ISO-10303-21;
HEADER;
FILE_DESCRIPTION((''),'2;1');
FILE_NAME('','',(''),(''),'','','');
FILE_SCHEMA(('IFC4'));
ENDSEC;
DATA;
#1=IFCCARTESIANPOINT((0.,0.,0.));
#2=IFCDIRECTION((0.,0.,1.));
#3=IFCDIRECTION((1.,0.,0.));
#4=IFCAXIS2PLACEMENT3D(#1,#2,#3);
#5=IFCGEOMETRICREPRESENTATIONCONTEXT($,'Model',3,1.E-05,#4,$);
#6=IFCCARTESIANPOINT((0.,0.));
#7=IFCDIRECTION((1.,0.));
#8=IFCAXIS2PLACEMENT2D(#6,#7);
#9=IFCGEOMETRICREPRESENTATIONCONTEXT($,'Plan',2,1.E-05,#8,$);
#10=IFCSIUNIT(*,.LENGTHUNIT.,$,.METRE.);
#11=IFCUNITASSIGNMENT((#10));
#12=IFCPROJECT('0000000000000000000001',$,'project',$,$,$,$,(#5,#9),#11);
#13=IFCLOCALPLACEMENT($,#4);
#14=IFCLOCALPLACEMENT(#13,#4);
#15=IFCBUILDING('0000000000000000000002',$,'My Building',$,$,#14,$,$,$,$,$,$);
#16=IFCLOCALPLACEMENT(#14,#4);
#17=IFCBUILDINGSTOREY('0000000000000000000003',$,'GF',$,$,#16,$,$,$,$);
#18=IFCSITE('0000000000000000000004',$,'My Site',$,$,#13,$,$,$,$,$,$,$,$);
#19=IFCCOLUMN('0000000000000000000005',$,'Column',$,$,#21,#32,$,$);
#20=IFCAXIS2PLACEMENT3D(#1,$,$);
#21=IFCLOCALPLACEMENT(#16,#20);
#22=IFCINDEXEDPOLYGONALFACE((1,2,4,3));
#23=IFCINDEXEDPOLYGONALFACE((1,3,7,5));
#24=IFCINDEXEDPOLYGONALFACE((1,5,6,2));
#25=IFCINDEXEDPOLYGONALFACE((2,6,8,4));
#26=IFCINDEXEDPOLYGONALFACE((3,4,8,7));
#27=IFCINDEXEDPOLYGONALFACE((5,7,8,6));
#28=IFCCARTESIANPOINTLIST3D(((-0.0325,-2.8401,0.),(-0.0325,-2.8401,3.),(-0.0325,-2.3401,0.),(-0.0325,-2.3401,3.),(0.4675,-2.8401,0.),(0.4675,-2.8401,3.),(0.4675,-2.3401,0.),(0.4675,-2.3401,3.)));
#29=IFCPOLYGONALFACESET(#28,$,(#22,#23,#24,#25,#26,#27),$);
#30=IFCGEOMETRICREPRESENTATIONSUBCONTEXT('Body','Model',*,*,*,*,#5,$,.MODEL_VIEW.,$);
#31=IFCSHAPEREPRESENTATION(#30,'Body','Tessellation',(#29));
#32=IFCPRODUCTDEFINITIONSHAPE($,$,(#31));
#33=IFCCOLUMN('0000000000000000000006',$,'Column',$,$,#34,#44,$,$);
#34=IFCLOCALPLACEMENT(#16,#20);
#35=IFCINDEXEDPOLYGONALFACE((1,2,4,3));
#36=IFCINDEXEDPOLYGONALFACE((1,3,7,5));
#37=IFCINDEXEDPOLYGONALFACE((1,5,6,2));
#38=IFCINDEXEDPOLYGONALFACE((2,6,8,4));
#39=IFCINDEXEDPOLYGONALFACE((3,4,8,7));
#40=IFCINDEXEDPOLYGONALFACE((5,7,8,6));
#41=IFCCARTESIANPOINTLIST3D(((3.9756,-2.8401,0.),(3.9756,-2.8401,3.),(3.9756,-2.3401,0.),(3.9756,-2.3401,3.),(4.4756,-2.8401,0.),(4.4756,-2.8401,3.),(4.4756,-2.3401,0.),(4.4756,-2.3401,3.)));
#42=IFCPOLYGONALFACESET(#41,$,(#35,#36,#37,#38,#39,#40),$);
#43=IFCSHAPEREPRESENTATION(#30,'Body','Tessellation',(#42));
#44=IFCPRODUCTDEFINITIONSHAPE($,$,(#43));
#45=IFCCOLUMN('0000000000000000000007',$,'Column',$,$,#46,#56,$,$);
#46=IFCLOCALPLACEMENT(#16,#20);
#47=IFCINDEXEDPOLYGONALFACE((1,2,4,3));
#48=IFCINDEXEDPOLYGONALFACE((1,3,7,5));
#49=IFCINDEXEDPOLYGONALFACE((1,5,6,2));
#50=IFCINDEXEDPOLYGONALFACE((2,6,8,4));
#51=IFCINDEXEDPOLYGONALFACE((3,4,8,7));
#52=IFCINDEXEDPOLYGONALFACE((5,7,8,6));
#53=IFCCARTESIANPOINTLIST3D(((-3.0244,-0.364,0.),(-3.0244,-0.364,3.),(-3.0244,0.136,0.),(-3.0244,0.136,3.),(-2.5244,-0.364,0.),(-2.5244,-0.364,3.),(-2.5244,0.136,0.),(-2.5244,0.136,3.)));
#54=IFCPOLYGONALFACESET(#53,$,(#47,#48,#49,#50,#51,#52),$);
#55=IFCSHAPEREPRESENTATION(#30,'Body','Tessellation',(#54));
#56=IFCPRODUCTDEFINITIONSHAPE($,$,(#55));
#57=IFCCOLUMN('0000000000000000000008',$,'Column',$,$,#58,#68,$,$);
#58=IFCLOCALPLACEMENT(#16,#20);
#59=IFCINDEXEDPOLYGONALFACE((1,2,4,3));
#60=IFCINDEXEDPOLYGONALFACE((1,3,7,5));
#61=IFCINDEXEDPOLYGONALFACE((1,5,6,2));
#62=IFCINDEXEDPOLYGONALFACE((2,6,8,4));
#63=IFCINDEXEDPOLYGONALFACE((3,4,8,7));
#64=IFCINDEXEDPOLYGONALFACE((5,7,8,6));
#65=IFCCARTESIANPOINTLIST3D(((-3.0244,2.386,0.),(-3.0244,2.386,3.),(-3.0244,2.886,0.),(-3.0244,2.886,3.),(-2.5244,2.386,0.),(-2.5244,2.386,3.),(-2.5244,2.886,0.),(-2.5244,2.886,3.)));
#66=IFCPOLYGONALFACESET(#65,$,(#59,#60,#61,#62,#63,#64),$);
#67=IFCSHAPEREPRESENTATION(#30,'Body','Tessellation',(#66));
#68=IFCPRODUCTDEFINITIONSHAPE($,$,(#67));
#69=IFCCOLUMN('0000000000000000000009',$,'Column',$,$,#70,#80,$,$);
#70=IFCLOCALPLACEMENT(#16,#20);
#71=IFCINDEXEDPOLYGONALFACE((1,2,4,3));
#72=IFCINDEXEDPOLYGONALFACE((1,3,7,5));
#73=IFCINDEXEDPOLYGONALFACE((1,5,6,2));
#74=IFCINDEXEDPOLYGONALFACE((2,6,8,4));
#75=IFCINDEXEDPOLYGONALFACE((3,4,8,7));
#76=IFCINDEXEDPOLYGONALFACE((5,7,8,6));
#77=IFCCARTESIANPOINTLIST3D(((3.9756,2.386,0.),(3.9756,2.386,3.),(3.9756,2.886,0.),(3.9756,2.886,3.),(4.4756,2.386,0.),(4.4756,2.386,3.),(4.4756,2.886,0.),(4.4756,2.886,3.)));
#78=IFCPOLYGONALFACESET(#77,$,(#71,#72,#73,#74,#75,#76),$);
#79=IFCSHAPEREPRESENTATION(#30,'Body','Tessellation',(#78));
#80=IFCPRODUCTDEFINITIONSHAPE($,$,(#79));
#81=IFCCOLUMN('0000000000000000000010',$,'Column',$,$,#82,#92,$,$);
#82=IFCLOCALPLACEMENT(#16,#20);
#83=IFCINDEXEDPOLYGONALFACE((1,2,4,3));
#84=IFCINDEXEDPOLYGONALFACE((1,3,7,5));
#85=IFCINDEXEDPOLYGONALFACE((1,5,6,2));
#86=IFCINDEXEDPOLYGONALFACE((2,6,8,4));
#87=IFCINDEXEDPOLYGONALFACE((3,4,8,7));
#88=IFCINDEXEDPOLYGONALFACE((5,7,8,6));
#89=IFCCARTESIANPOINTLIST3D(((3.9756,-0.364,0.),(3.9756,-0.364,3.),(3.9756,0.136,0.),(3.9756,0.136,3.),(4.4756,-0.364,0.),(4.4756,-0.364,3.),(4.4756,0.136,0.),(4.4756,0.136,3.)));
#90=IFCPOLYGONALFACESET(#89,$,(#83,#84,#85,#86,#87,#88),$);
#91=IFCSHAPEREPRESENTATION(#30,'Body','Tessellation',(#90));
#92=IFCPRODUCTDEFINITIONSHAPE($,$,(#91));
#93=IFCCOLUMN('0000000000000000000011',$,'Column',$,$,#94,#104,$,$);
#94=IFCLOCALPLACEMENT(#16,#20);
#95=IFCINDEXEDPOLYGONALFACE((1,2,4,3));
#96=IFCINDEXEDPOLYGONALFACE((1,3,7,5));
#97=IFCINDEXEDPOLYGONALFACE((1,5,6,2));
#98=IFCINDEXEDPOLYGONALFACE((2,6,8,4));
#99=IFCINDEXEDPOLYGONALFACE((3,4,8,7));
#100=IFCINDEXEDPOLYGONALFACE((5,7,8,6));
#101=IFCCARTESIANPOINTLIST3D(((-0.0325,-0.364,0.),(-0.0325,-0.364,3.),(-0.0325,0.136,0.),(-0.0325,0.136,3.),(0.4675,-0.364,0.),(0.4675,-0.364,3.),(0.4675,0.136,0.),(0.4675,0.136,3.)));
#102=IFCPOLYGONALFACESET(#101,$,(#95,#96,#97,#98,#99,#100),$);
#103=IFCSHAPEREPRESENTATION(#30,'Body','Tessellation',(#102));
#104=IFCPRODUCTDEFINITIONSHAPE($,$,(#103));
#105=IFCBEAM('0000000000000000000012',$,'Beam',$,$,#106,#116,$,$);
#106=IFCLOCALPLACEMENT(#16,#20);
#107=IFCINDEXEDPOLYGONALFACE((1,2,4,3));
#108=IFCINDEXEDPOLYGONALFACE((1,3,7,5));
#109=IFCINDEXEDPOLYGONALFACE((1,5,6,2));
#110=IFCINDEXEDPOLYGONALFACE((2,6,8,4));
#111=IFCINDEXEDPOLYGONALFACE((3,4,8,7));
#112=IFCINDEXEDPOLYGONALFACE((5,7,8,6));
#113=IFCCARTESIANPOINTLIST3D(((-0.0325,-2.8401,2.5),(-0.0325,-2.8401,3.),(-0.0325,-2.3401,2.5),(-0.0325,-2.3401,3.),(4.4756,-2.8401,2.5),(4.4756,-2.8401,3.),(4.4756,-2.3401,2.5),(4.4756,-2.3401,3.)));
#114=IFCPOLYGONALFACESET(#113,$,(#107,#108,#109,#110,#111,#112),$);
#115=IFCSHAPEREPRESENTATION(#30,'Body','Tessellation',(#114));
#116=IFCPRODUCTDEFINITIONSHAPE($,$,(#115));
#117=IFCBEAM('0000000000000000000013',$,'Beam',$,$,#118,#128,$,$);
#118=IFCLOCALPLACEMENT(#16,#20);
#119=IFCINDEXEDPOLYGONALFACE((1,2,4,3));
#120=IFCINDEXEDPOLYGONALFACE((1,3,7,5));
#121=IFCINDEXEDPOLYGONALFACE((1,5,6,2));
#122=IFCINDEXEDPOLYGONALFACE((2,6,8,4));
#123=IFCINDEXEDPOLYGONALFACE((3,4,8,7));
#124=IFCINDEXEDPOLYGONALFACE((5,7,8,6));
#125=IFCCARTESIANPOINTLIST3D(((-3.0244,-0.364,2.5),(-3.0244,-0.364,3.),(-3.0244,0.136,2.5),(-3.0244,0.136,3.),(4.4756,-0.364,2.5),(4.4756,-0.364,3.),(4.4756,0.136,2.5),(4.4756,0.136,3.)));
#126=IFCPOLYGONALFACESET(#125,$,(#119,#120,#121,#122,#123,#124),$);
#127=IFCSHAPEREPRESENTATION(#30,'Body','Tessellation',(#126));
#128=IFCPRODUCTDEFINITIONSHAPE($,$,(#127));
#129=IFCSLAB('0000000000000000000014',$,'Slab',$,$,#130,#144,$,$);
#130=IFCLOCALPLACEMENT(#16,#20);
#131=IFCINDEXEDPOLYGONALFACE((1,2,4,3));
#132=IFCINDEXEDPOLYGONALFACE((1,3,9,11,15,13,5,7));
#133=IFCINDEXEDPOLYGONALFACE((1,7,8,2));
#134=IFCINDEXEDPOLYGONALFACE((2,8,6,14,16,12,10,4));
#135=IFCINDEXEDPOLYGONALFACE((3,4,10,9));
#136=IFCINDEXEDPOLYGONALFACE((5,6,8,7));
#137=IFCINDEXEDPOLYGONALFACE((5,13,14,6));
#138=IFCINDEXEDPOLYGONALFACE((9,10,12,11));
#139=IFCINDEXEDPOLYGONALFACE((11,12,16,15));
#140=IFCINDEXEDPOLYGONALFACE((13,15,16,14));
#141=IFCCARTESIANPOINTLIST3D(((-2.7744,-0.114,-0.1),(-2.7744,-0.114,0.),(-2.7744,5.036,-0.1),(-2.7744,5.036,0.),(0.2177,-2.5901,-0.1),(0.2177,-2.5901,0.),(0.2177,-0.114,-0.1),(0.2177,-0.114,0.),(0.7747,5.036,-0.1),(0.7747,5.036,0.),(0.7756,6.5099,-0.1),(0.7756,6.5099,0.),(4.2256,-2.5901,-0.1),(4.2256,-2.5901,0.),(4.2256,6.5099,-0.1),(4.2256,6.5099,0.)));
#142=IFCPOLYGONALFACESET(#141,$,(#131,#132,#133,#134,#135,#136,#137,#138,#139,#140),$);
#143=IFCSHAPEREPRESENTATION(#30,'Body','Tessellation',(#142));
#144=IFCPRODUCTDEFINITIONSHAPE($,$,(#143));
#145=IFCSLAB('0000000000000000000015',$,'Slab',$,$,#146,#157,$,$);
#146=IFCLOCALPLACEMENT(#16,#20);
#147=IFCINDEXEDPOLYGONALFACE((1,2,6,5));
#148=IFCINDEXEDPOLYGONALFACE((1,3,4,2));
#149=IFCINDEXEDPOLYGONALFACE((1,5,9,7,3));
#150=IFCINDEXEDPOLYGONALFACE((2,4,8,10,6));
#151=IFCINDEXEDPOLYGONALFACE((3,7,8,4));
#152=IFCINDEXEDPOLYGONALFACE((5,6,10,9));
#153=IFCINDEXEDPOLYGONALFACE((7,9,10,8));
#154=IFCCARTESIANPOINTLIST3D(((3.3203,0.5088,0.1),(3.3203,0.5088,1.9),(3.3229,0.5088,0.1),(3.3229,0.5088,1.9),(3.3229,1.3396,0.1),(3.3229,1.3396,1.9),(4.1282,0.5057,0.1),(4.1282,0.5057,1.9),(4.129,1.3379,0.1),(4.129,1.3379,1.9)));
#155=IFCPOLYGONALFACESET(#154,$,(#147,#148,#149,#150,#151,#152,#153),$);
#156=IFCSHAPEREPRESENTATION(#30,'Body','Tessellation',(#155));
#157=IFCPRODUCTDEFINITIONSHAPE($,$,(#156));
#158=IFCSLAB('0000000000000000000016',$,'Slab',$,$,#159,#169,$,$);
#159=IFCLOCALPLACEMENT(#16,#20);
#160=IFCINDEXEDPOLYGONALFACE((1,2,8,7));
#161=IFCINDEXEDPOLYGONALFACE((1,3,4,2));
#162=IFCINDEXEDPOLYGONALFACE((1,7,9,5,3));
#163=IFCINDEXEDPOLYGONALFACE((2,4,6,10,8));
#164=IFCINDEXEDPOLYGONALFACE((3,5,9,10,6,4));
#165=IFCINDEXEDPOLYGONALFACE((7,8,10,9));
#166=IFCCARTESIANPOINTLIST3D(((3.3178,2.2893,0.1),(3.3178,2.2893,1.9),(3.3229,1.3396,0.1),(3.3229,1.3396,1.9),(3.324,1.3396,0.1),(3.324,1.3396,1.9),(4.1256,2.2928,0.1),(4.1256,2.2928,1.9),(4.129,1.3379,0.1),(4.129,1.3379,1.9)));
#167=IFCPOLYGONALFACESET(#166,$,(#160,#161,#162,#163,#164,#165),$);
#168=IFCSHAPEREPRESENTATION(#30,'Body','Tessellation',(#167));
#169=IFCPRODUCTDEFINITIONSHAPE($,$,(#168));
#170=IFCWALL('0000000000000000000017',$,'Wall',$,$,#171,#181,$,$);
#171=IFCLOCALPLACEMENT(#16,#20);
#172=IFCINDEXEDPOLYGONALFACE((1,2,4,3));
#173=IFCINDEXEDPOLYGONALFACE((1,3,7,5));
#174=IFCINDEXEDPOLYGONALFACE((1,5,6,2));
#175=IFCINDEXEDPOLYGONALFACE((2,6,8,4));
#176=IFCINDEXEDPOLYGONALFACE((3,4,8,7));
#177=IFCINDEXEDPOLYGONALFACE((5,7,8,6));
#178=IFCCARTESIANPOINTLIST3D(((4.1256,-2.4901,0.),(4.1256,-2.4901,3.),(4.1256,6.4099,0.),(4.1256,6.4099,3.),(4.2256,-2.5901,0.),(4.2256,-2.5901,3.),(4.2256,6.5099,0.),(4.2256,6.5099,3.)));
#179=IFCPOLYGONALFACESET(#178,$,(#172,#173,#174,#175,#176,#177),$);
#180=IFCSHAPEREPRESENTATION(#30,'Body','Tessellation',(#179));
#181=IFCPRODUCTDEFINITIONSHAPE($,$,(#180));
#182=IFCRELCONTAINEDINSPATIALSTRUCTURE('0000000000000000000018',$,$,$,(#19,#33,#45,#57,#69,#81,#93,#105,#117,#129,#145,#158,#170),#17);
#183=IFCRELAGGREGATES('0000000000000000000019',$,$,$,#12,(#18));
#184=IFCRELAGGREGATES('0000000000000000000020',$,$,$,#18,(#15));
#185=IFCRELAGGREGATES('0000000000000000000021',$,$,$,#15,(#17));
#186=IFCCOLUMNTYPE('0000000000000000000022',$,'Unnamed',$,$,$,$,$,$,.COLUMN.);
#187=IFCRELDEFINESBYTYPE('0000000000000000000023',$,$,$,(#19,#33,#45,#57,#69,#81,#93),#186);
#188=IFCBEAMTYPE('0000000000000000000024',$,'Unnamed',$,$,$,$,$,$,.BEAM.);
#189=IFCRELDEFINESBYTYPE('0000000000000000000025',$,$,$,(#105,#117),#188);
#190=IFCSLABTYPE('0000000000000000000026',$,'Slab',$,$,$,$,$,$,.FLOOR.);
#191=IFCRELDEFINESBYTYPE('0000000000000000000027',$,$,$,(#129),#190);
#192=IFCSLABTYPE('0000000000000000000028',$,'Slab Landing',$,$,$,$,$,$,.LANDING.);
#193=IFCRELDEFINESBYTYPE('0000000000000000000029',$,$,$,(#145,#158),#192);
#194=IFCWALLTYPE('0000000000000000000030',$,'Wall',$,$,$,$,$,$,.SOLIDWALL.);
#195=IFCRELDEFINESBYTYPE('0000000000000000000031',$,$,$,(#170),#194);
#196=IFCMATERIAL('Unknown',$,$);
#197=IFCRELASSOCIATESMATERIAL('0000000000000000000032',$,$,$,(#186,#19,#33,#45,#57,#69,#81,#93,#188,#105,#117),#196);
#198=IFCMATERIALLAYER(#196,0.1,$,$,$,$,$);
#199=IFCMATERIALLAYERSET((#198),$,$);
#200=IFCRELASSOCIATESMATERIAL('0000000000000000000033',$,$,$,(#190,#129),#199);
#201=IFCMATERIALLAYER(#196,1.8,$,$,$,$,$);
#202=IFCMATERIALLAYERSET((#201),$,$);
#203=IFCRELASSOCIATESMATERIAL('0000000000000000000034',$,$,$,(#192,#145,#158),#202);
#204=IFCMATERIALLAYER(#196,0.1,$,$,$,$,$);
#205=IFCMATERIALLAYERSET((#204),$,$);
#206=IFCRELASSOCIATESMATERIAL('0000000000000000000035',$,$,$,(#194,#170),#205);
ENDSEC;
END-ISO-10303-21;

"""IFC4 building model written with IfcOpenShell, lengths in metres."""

from ifc_helpers import new_model, si_unit, frame, origin_with_axes, origin_2d_with_axis, place, context, subcontext, project, spatial, line, indexed_curve, rectangle, outline, extrude, material, layer, layer_set, layer_usage, material_profile, profile_set, profile_usage, type_object, element, save


model = new_model("IFC4")

# Units and contexts
model_context = context("Model", 3, precision=1e-05, world=origin_with_axes())
plan_context = context("Plan", 2, precision=1e-05, world=origin_2d_with_axis())
body_context_1 = subcontext(model_context, "Body", "Model", "MODEL_VIEW")
ifc_project = project(units=[si_unit("LENGTHUNIT", "METRE")], contexts=[model_context, plan_context])

# Site, building, storey
site_placement = place(None, origin_with_axes())
site = spatial("IfcSite", under=ifc_project, at=site_placement, Name="My Site")
building_placement = place(site_placement, origin_with_axes())
building = spatial("IfcBuilding", under=site, at=building_placement, Name="My Building")
storey_placement = place(building_placement, origin_with_axes())
storey = spatial("IfcBuildingStorey", under=building, at=storey_placement, Name="GF")

# Columns
ifc_material = material(Name="Unknown")
ifc_material_profile_1 = material_profile(ifc_material, rectangle(XDim=0.5, YDim=0.5))
ifc_profile_set_1 = profile_set([ifc_material_profile_1])
ifc_profile_usage_1 = profile_usage(ifc_profile_set_1, cardinal=5)
column_type = type_object("IfcColumnType", Name="Unnamed", PredefinedType="COLUMN", material=ifc_profile_set_1)
column_1_placement = place(storey_placement, frame((0.2175, -2.5901, 0.0), z_axis=(0.0, 0.0, 1.0), x_axis=(1.0, 0.0, 0.0)))
element("IfcColumn", 1, at=column_1_placement, inside=storey, type_object=column_type, material=ifc_profile_usage_1, Name="Column", context=body_context_1, shape_type="SweptSolid", body=[
    extrude(rectangle(XDim=0.5, YDim=0.5), origin_with_axes(), (0.0, 0.0, 1.0), 3.0),
])
ifc_profile_usage_2 = profile_usage(ifc_profile_set_1, cardinal=5)
column_2_placement = place(storey_placement, frame((4.2256, -2.5901, 0.0), z_axis=(0.0, 0.0, 1.0), x_axis=(1.0, 0.0, 0.0)))
element("IfcColumn", 2, at=column_2_placement, inside=storey, type_object=column_type, material=ifc_profile_usage_2, Name="Column", context=body_context_1, shape_type="SweptSolid", body=[
    extrude(rectangle(XDim=0.5, YDim=0.5), origin_with_axes(), (0.0, 0.0, 1.0), 3.0),
])
ifc_profile_usage_3 = profile_usage(ifc_profile_set_1, cardinal=5)
column_3_placement = place(storey_placement, frame((-2.7744, -0.114, 0.0), z_axis=(0.0, 0.0, 1.0), x_axis=(1.0, 0.0, 0.0)))
element("IfcColumn", 3, at=column_3_placement, inside=storey, type_object=column_type, material=ifc_profile_usage_3, Name="Column", context=body_context_1, shape_type="SweptSolid", body=[
    extrude(rectangle(XDim=0.5, YDim=0.5), origin_with_axes(), (0.0, 0.0, 1.0), 3.0),
])
ifc_profile_usage_4 = profile_usage(ifc_profile_set_1, cardinal=5)
column_4_placement = place(storey_placement, frame((-2.7744, 2.636, 0.0), z_axis=(0.0, 0.0, 1.0), x_axis=(1.0, 0.0, 0.0)))
element("IfcColumn", 4, at=column_4_placement, inside=storey, type_object=column_type, material=ifc_profile_usage_4, Name="Column", context=body_context_1, shape_type="SweptSolid", body=[
    extrude(rectangle(XDim=0.5, YDim=0.5), origin_with_axes(), (0.0, 0.0, 1.0), 3.0),
])
ifc_profile_usage_5 = profile_usage(ifc_profile_set_1, cardinal=5)
column_5_placement = place(storey_placement, frame((4.2256, 2.636, 0.0), z_axis=(0.0, 0.0, 1.0), x_axis=(1.0, 0.0, 0.0)))
element("IfcColumn", 5, at=column_5_placement, inside=storey, type_object=column_type, material=ifc_profile_usage_5, Name="Column", context=body_context_1, shape_type="SweptSolid", body=[
    extrude(rectangle(XDim=0.5, YDim=0.5), origin_with_axes(), (0.0, 0.0, 1.0), 3.0),
])
ifc_profile_usage_6 = profile_usage(ifc_profile_set_1, cardinal=5)
column_6_placement = place(storey_placement, frame((4.2256, -0.114, 0.0), z_axis=(0.0, 0.0, 1.0), x_axis=(1.0, 0.0, 0.0)))
element("IfcColumn", 6, at=column_6_placement, inside=storey, type_object=column_type, material=ifc_profile_usage_6, Name="Column", context=body_context_1, shape_type="SweptSolid", body=[
    extrude(rectangle(XDim=0.5, YDim=0.5), origin_with_axes(), (0.0, 0.0, 1.0), 3.0),
])
ifc_profile_usage_7 = profile_usage(ifc_profile_set_1, cardinal=5)
column_7_placement = place(storey_placement, frame((0.2175, -0.114, 0.0), z_axis=(0.0, 0.0, 1.0), x_axis=(1.0, 0.0, 0.0)))
element("IfcColumn", 7, at=column_7_placement, inside=storey, type_object=column_type, material=ifc_profile_usage_7, Name="Column", context=body_context_1, shape_type="SweptSolid", body=[
    extrude(rectangle(XDim=0.5, YDim=0.5), origin_with_axes(), (0.0, 0.0, 1.0), 3.0),
])

# Beams
ifc_material_profile_2 = material_profile(ifc_material, rectangle(XDim=0.5, YDim=0.5))
ifc_profile_set_2 = profile_set([ifc_material_profile_2])
ifc_profile_usage_8 = profile_usage(ifc_profile_set_2, cardinal=7)
beam_type = type_object("IfcBeamType", Name="Unnamed", PredefinedType="BEAM", material=ifc_profile_set_2)
beam_1_placement = place(storey_placement, frame((-0.0325, -2.3401, 3.0), z_axis=(1.0, 0.0, 0.0), x_axis=(0.0, 1.0, 0.0)))
element("IfcBeam", 8, at=beam_1_placement, inside=storey, type_object=beam_type, material=ifc_profile_usage_8, Name="Beam", context=body_context_1, shape_type="SweptSolid", body=[
    extrude(rectangle(XDim=0.5, YDim=0.5), frame((-0.25, -0.25, 0.0), z_axis=(0.0, 0.0, 1.0), x_axis=(1.0, 0.0, 0.0)), (0.0, 0.0, 1.0), 4.5081),
])
ifc_profile_usage_9 = profile_usage(ifc_profile_set_2, cardinal=7)
beam_2_placement = place(storey_placement, frame((-3.0244, 0.136, 3.0), z_axis=(1.0, 0.0, 0.0), x_axis=(0.0, 1.0, 0.0)))
element("IfcBeam", 9, at=beam_2_placement, inside=storey, type_object=beam_type, material=ifc_profile_usage_9, Name="Beam", context=body_context_1, shape_type="SweptSolid", body=[
    extrude(rectangle(XDim=0.5, YDim=0.5), frame((-0.25, -0.25, 0.0), z_axis=(0.0, 0.0, 1.0), x_axis=(1.0, 0.0, 0.0)), (0.0, 0.0, 1.0), 7.5),
])

# Slabs
ifc_layer_1 = layer(ifc_material, 0.1)
ifc_layer_set_1 = layer_set([ifc_layer_1])
ifc_layer_usage_1 = layer_usage(ifc_layer_set_1, "AXIS3", "POSITIVE", -0.1)
slab_type_1 = type_object("IfcSlabType", Name="Slab", PredefinedType="FLOOR", material=ifc_layer_set_1)
slab_1_placement = place(storey_placement, frame((4.2256, -2.5901, 0.0), z_axis=(0.0, 0.0, 1.0), x_axis=(1.0, 0.0, 0.0)))
element("IfcSlab", 10, at=slab_1_placement, inside=storey, type_object=slab_type_1, material=ifc_layer_usage_1, Name="Slab", context=body_context_1, shape_type="SweptSolid", body=[
    extrude(outline(indexed_curve([(0.0, 0.0), (0.0, 9.1), (-3.45, 9.1), (-3.4508, 7.6261), (-7.0, 7.6261), (-7.0, 2.4761), (-4.0079, 2.4761), (-4.0079, 0.0), (0.0, 0.0)])), frame((0.0, 0.0, -0.1), z_axis=(0.0, 0.0, 1.0), x_axis=(1.0, 0.0, 0.0)), (0.0, 0.0, 1.0), 0.1),
])
ifc_layer_2 = layer(ifc_material, 1.8)
ifc_layer_set_2 = layer_set([ifc_layer_2])
ifc_layer_usage_2 = layer_usage(ifc_layer_set_2, "AXIS3", "POSITIVE", -0.1)
slab_type_2 = type_object("IfcSlabType", Name="Slab Landing", PredefinedType="LANDING", material=ifc_layer_set_2)
slab_2_placement = place(storey_placement, frame((3.3229, 0.5088, 0.2), z_axis=(0.0, 0.0, 1.0), x_axis=(1.0, 0.0, 0.0)))
element("IfcSlab", 11, at=slab_2_placement, inside=storey, type_object=slab_type_2, material=ifc_layer_usage_2, Name="Slab", context=body_context_1, shape_type="SweptSolid", body=[
    extrude(outline(indexed_curve([(-0.0026, 0.0), (0.0, 0.8308), (0.806, 0.8291), (0.8053, -0.0031), (0.0, 0.0), (-0.0026, 0.0)])), frame((0.0, 0.0, -0.1), z_axis=(0.0, 0.0, 1.0), x_axis=(1.0, 0.0, 0.0)), (0.0, 0.0, 1.0), 1.8),
])
ifc_layer_usage_3 = layer_usage(ifc_layer_set_2, "AXIS3", "POSITIVE", -1.8)
slab_3_placement = place(storey_placement, frame((3.324, 1.3396, 1.9), z_axis=(0.0, 0.0, 1.0), x_axis=(1.0, 0.0, 0.0)))
element("IfcSlab", 12, at=slab_3_placement, inside=storey, type_object=slab_type_2, material=ifc_layer_usage_3, Name="Slab", context=body_context_1, shape_type="SweptSolid", body=[
    extrude(outline(indexed_curve([(-0.001, 0.0), (-0.0061, 0.9497), (0.8016, 0.9532), (0.805, -0.0017), (0.0, 0.0), (-0.001, 0.0)])), frame((0.0, 0.0, -1.8), z_axis=(0.0, 0.0, 1.0), x_axis=(1.0, 0.0, 0.0)), (0.0, 0.0, 1.0), 1.8),
])

# Shared definitions
ifc_layer_3 = layer(ifc_material, 0.1)
ifc_layer_set_3 = layer_set([ifc_layer_3])
wall_type = type_object("IfcWallType", Name="Wall", PredefinedType="SOLIDWALL", material=ifc_layer_set_3)

# Wall
ifc_layer_usage_4 = layer_usage(ifc_layer_set_3, "AXIS2", "POSITIVE", 0.0)
wall_1_placement = place(storey_placement, frame((4.2256, -2.5901, 0.0), z_axis=(0.0, 0.0, 1.0), x_axis=(0.0, 1.0, 0.0)))
element("IfcWall", 13, at=wall_1_placement, inside=storey, type_object=wall_type, material=ifc_layer_usage_4, Name="Wall", context=body_context_1, shape_type="SweptSolid", body=[
    extrude(outline(indexed_curve([(0.0, 0.0), (0.1, 0.1), (9.0, 0.1), (9.1, 0.0)], segments=[line(1, 2, 3, 4, 1)])), origin_with_axes(), (0.0, 0.0, 1.0), 3.0),
])

save(model, "model.ifc")
